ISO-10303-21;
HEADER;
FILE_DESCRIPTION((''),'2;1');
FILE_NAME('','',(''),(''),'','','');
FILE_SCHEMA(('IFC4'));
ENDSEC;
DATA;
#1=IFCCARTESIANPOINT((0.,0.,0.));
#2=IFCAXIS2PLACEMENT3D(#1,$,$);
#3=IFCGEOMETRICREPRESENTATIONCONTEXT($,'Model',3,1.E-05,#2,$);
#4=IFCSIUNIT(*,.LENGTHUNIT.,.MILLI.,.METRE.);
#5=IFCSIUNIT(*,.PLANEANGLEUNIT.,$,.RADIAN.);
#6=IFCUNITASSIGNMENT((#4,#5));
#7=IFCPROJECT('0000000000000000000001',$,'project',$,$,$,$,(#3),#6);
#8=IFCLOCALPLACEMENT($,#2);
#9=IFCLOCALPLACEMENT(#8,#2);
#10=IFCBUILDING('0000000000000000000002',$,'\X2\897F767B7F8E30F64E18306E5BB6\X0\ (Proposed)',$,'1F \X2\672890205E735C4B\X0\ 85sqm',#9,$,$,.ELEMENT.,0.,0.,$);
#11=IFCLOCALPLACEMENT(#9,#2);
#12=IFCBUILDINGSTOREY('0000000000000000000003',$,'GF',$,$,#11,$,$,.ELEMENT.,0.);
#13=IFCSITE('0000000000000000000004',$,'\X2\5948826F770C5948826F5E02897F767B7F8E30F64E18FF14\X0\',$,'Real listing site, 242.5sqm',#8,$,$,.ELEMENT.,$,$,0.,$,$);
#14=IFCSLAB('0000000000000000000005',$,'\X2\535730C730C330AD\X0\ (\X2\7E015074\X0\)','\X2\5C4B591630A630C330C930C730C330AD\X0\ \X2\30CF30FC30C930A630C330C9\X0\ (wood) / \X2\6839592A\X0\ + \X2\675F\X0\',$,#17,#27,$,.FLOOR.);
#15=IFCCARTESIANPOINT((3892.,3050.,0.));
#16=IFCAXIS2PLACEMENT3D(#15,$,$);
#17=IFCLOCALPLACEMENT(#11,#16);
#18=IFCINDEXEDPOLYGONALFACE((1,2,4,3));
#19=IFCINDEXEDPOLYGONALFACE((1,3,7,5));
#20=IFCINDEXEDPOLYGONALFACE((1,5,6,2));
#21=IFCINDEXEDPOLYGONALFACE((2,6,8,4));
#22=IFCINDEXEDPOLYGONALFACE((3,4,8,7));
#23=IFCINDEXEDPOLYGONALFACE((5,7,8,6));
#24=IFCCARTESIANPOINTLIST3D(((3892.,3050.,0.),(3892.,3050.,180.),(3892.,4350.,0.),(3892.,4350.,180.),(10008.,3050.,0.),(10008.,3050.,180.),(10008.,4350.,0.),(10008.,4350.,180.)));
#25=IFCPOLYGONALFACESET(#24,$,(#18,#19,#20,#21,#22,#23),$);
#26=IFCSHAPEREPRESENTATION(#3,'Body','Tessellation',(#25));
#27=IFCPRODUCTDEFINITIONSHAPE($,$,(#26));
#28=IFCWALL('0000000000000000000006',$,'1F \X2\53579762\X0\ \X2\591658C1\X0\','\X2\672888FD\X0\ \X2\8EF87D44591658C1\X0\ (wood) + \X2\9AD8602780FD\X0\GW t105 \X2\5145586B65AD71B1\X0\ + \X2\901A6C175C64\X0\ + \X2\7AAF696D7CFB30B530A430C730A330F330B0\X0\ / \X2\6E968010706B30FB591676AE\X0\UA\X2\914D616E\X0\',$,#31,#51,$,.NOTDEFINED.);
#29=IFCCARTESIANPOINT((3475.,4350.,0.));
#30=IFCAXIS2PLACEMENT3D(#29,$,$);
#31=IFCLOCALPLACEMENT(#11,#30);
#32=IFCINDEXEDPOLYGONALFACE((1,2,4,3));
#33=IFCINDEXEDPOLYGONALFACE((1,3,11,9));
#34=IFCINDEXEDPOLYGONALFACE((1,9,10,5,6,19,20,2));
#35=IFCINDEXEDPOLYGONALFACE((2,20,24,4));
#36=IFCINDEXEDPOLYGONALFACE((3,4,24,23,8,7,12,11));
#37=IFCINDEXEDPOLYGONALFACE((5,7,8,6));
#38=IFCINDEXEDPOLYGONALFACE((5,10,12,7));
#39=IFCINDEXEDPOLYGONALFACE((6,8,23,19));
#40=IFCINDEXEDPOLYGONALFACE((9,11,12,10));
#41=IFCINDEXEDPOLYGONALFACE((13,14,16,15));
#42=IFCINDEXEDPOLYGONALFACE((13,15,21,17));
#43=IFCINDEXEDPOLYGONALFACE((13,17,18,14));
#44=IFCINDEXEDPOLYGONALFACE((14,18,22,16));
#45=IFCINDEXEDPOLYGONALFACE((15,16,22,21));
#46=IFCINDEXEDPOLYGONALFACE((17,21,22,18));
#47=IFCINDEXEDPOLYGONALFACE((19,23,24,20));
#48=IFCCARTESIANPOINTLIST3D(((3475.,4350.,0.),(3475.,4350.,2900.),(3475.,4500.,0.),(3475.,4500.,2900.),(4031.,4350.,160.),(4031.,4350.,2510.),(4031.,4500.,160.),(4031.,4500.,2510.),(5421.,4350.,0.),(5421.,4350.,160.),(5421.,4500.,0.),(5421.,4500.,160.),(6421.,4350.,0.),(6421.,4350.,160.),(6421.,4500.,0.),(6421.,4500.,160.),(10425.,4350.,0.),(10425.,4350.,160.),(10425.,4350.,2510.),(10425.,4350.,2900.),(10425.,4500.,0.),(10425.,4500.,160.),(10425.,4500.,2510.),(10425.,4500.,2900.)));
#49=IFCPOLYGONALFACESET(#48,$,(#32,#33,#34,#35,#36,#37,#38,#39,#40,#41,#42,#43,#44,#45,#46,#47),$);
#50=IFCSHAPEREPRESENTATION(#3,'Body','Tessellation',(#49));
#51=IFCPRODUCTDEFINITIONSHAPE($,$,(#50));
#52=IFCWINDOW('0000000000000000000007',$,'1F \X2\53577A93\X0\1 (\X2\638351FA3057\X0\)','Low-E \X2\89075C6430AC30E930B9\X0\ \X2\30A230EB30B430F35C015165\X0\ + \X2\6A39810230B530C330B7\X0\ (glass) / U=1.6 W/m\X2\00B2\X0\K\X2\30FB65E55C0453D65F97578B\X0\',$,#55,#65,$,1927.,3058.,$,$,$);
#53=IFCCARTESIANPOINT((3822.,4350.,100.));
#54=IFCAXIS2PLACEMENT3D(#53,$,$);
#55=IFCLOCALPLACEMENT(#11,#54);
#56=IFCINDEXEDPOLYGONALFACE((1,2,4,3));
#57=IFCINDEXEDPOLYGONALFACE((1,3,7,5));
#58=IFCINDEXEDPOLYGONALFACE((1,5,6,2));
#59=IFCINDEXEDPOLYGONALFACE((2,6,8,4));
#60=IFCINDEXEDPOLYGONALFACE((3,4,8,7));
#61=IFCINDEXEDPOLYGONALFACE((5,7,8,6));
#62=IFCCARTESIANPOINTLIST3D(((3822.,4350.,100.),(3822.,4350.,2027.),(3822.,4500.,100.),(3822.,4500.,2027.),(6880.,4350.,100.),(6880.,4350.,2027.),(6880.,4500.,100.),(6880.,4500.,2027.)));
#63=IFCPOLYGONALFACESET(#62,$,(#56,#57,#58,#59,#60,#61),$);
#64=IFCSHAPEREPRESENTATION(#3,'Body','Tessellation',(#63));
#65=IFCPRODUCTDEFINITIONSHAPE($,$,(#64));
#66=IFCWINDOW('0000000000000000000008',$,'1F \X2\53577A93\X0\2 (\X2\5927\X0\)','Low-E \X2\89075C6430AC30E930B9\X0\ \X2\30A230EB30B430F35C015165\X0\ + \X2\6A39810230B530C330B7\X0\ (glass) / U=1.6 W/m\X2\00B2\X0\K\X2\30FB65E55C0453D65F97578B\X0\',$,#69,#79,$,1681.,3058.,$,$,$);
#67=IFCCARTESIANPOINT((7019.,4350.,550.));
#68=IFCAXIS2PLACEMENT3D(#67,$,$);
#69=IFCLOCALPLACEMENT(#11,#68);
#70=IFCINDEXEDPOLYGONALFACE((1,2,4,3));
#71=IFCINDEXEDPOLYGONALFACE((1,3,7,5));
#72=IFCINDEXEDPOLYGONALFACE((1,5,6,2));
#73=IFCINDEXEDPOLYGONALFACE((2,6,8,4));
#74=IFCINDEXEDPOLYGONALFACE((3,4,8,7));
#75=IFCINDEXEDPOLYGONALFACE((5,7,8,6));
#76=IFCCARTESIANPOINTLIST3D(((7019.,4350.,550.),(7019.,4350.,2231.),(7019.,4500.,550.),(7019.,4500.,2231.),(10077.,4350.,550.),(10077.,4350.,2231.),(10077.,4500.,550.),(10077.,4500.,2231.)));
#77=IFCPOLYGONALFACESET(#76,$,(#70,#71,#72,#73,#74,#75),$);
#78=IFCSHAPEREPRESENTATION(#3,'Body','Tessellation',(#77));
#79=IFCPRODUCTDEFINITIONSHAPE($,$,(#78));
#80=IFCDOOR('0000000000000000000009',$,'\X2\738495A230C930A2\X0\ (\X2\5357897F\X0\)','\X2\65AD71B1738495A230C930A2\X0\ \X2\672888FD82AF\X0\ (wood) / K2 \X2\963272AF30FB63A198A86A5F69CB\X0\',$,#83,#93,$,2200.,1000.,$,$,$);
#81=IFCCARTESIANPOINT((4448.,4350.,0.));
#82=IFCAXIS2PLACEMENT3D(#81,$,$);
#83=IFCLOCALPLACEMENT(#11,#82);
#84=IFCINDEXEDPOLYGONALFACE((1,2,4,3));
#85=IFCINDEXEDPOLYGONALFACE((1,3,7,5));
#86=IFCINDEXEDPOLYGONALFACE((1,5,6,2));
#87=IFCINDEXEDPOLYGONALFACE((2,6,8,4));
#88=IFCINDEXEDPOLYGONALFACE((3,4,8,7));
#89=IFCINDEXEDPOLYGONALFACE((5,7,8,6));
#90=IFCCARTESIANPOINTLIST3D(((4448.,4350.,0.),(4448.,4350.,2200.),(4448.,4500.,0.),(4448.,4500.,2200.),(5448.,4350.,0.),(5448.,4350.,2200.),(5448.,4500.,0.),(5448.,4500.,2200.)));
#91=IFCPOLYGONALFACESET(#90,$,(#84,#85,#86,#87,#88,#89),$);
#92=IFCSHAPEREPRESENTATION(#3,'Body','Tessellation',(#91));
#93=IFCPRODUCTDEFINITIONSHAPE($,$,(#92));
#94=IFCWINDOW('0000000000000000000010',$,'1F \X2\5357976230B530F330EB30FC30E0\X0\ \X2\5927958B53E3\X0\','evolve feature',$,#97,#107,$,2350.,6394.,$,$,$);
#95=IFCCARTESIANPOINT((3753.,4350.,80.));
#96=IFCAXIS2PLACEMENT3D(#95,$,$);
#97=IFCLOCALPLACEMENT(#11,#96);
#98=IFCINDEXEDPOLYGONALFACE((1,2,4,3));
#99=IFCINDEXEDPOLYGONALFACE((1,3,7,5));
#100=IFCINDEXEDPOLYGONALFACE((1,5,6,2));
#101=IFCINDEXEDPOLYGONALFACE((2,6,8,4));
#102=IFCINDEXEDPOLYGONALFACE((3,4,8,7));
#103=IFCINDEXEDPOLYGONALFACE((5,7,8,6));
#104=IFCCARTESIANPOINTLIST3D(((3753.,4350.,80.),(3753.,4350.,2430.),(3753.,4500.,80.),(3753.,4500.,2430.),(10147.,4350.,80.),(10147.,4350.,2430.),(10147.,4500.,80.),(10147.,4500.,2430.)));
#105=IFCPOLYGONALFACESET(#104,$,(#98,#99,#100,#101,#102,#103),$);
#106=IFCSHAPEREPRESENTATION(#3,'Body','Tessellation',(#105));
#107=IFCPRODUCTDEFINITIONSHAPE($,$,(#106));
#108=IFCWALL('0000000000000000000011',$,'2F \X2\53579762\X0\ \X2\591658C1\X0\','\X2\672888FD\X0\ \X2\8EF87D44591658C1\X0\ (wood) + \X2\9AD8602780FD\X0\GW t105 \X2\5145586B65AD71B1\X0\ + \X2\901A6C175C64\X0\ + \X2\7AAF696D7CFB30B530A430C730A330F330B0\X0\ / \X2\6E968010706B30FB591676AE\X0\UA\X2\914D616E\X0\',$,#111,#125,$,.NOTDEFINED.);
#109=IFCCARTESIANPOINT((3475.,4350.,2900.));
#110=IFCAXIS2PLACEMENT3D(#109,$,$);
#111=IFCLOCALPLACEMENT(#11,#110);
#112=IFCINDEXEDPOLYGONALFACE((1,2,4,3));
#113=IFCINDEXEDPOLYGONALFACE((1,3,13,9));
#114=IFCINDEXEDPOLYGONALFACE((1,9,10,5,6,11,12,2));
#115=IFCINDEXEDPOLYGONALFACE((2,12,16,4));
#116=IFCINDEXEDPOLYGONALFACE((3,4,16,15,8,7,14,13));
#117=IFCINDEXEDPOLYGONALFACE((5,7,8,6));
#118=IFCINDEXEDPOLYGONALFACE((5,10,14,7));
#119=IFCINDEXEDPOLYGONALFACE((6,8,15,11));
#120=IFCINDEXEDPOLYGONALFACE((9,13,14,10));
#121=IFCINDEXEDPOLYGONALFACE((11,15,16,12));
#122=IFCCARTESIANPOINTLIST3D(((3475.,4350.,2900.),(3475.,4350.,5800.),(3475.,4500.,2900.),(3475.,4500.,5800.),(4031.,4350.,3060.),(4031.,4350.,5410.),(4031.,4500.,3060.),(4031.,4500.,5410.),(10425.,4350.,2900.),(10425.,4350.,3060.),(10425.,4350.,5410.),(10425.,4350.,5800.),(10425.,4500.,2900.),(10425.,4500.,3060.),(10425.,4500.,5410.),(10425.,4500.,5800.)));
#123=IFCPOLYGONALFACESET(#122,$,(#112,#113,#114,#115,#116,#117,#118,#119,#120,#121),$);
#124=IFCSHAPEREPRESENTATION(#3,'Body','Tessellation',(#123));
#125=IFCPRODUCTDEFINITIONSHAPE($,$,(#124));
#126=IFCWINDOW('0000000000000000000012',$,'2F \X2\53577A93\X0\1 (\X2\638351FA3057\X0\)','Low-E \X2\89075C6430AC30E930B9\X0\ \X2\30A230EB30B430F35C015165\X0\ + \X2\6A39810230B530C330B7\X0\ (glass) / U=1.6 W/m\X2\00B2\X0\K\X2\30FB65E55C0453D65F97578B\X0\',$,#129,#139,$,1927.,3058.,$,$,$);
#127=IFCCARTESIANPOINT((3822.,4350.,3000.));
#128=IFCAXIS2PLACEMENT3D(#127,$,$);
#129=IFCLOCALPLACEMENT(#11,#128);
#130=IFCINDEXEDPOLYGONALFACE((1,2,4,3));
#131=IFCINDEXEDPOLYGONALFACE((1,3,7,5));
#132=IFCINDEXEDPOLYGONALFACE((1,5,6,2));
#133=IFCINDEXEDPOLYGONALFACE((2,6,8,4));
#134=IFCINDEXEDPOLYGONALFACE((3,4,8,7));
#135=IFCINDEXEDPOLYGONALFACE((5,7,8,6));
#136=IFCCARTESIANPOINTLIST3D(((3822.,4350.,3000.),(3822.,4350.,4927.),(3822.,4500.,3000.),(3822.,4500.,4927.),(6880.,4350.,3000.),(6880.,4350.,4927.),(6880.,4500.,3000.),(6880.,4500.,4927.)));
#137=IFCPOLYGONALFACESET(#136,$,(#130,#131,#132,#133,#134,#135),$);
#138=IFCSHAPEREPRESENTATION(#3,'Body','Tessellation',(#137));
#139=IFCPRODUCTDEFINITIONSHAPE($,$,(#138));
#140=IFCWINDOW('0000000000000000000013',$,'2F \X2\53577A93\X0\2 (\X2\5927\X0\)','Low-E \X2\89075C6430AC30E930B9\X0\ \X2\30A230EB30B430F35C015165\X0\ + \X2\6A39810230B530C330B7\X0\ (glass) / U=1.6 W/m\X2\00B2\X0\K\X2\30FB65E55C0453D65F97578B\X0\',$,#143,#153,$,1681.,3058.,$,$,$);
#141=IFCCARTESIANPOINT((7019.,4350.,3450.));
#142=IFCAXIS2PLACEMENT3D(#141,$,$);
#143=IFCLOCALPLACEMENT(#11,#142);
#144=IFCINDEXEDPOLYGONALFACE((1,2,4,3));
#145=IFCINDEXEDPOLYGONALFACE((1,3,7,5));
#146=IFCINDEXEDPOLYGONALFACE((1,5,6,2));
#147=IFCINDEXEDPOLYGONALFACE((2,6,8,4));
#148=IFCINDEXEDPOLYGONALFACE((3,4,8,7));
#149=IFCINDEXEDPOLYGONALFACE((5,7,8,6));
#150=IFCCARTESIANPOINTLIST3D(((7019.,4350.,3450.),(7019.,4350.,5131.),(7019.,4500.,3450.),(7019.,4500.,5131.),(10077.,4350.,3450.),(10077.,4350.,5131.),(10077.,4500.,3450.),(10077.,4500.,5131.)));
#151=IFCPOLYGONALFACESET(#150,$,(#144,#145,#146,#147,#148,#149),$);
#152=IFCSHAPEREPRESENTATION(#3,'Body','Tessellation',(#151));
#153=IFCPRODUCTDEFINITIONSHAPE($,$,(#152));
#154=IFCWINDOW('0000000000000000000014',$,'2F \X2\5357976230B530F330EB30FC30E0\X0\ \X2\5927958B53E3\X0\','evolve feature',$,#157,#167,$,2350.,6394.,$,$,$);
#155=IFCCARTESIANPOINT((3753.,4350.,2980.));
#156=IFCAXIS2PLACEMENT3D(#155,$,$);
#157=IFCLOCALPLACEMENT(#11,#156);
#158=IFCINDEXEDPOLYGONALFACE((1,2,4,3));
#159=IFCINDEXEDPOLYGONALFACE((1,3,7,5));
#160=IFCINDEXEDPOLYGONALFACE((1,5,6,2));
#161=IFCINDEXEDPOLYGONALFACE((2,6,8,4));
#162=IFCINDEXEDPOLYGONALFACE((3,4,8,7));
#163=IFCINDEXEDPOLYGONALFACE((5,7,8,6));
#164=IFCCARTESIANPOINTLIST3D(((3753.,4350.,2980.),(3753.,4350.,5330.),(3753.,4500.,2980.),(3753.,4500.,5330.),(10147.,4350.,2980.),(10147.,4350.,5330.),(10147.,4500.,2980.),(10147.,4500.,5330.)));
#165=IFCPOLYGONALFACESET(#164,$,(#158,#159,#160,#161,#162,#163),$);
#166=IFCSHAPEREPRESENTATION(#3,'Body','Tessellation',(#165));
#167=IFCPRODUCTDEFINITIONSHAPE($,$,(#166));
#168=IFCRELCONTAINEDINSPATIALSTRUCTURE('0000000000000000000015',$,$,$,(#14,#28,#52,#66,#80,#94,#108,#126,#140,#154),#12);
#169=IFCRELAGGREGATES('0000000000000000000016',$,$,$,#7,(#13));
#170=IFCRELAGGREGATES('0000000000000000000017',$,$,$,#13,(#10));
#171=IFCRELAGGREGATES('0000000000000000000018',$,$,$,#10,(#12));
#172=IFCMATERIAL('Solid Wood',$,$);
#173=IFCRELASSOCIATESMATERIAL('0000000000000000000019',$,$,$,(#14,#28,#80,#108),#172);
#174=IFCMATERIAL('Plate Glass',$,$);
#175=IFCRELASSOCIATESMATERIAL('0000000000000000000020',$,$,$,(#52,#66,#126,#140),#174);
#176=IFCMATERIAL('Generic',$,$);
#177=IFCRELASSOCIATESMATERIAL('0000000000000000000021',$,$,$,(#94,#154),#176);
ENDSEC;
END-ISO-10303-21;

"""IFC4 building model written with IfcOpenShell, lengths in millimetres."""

from ifc_helpers import new_model, si_unit, frame, frame_2d, origin, place, context, project, spatial, rectangle, extrude, material, element, fill, save


model = new_model("IFC4")

# Units and contexts
model_context = context("Model", 3, precision=1e-05, world=origin())
ifc_project = project(units=[si_unit("LENGTHUNIT", "METRE", prefix="MILLI"), si_unit("PLANEANGLEUNIT", "RADIAN")], contexts=[model_context])

# Site, building, storey
site_placement = place(None, origin())
site = spatial("IfcSite", under=ifc_project, at=site_placement, Name="奈良県奈良市西登美ヶ丘４", ObjectType="Real listing site, 242.5sqm", CompositionType="ELEMENT", RefElevation=0.0)
building_placement = place(site_placement, origin())
building = spatial("IfcBuilding", under=site, at=building_placement, Name="西登美ヶ丘の家 (Proposed)", ObjectType="1F 木造平屋 85sqm", CompositionType="ELEMENT", ElevationOfRefHeight=0.0, ElevationOfTerrain=0.0)
storey_placement = place(building_placement, origin())
storey = spatial("IfcBuildingStorey", under=building, at=storey_placement, Name="GF", CompositionType="ELEMENT", Elevation=0.0)

# Slab
ifc_material_1 = material(Name="Solid Wood")
slab_1_placement = place(storey_placement, frame((3892.0, 3050.0, 0.0)))
element("IfcSlab", 1, at=slab_1_placement, inside=storey, material=ifc_material_1, Name="南デッキ (縁側)", Description="屋外ウッドデッキ ハードウッド (wood) / 根太 + 束", PredefinedType="FLOOR", context=model_context, shape_type="SweptSolid", body=[
    extrude(rectangle(XDim=6116.0, YDim=1300.0, at=frame_2d((3058.0, 650.0))), frame((3892.0, 3050.0, 0.0)), (0.0, 0.0, 1.0), 180.0),
])
ifc_material_2 = material(Name="Generic")

# Wall, openings, windows, door
wall_1_placement = place(storey_placement, frame((3475.0, 4350.0, 0.0)))
wall_1 = element("IfcWall", 2, at=wall_1_placement, inside=storey, material=ifc_material_1, Name="1F 南面 外壁", Description="木製 軸組外壁 (wood) + 高性能GW t105 充填断熱 + 通気層 + 窯業系サイディング / 準耐火・外皮UA配慮", PredefinedType="NOTDEFINED", context=model_context, shape_type="SweptSolid", body=[
    extrude(rectangle(XDim=6950.0, YDim=150.0, at=frame_2d((3475.0, 75.0))), frame((3475.0, 4350.0, 0.0)), (0.0, 0.0, 1.0), 2900.0),
])
opening_1_placement = place(storey_placement, frame((3822.0, 4350.0, 100.0)))
opening_1 = element("IfcOpeningElement", 3, at=opening_1_placement, cuts=wall_1, PredefinedType="NOTDEFINED", context=model_context, shape_type="SweptSolid", body=[
    extrude(rectangle(XDim=3058.0, YDim=150.0, at=frame_2d((1529.0, 75.0))), frame((3822.0, 4350.0, 100.0)), (0.0, 0.0, 1.0), 1927.0),
])
opening_2_placement = place(storey_placement, frame((7019.0, 4350.0, 550.0)))
opening_2 = element("IfcOpeningElement", 4, at=opening_2_placement, cuts=wall_1, PredefinedType="NOTDEFINED", context=model_context, shape_type="SweptSolid", body=[
    extrude(rectangle(XDim=3058.0, YDim=150.0, at=frame_2d((1529.0, 75.0))), frame((7019.0, 4350.0, 550.0)), (0.0, 0.0, 1.0), 1681.0),
])
opening_3_placement = place(storey_placement, frame((4448.0, 4350.0, 0.0)))
opening_3 = element("IfcOpeningElement", 5, at=opening_3_placement, cuts=wall_1, PredefinedType="NOTDEFINED", context=model_context, shape_type="SweptSolid", body=[
    extrude(rectangle(XDim=1000.0, YDim=150.0, at=frame_2d((500.0, 75.0))), frame((4448.0, 4350.0, 0.0)), (0.0, 0.0, 1.0), 2200.0),
])
opening_4_placement = place(storey_placement, frame((3753.0, 4350.0, 80.0)))
opening_4 = element("IfcOpeningElement", 6, at=opening_4_placement, cuts=wall_1, PredefinedType="NOTDEFINED", context=model_context, shape_type="SweptSolid", body=[
    extrude(rectangle(XDim=6394.0, YDim=150.0, at=frame_2d((3197.0, 75.0))), frame((3753.0, 4350.0, 80.0)), (0.0, 0.0, 1.0), 2350.0),
])
ifc_material_3 = material(Name="Plate Glass")
window_1_placement = place(storey_placement, frame((3822.0, 4350.0, 100.0)))
window_1 = element("IfcWindow", 7, at=window_1_placement, inside=storey, material=ifc_material_3, Name="1F 南窓1 (掃出し)", Description="Low-E 複層ガラス アルゴン封入 + 樹脂サッシ (glass) / U=1.6 W/m²K・日射取得型", OverallHeight=1927.0, OverallWidth=3058.0, context=model_context, shape_type="SweptSolid", body=[
    extrude(rectangle(XDim=3058.0, YDim=150.0, at=frame_2d((1529.0, 75.0))), frame((3822.0, 4350.0, 100.0)), (0.0, 0.0, 1.0), 1927.0),
])
fill(opening_1, window_1)
window_2_placement = place(storey_placement, frame((7019.0, 4350.0, 550.0)))
window_2 = element("IfcWindow", 8, at=window_2_placement, inside=storey, material=ifc_material_3, Name="1F 南窓2 (大)", Description="Low-E 複層ガラス アルゴン封入 + 樹脂サッシ (glass) / U=1.6 W/m²K・日射取得型", OverallHeight=1681.0, OverallWidth=3058.0, context=model_context, shape_type="SweptSolid", body=[
    extrude(rectangle(XDim=3058.0, YDim=150.0, at=frame_2d((1529.0, 75.0))), frame((7019.0, 4350.0, 550.0)), (0.0, 0.0, 1.0), 1681.0),
])
fill(opening_2, window_2)
door_placement = place(storey_placement, frame((4448.0, 4350.0, 0.0)))
door = element("IfcDoor", 9, at=door_placement, inside=storey, material=ifc_material_1, Name="玄関ドア (南西)", Description="断熱玄関ドア 木製芯 (wood) / K2 防犯・採風機構", OverallHeight=2200.0, OverallWidth=1000.0, context=model_context, shape_type="SweptSolid", body=[
    extrude(rectangle(XDim=1000.0, YDim=150.0, at=frame_2d((500.0, 75.0))), frame((4448.0, 4350.0, 0.0)), (0.0, 0.0, 1.0), 2200.0),
])
fill(opening_3, door)
window_3_placement = place(storey_placement, frame((3753.0, 4350.0, 80.0)))
window_3 = element("IfcWindow", 10, at=window_3_placement, inside=storey, material=ifc_material_2, Name="1F 南面サンルーム 大開口", Description="evolve feature", OverallHeight=2350.0, OverallWidth=6394.0, context=model_context, shape_type="SweptSolid", body=[
    extrude(rectangle(XDim=6394.0, YDim=150.0, at=frame_2d((3197.0, 75.0))), frame((3753.0, 4350.0, 80.0)), (0.0, 0.0, 1.0), 2350.0),
])
fill(opening_4, window_3)

# Wall, openings, windows
wall_2_placement = place(storey_placement, frame((3475.0, 4350.0, 2900.0)))
wall_2 = element("IfcWall", 11, at=wall_2_placement, inside=storey, material=ifc_material_1, Name="2F 南面 外壁", Description="木製 軸組外壁 (wood) + 高性能GW t105 充填断熱 + 通気層 + 窯業系サイディング / 準耐火・外皮UA配慮", PredefinedType="NOTDEFINED", context=model_context, shape_type="SweptSolid", body=[
    extrude(rectangle(XDim=6950.0, YDim=150.0, at=frame_2d((3475.0, 75.0))), frame((3475.0, 4350.0, 2900.0)), (0.0, 0.0, 1.0), 2900.0),
])
opening_5_placement = place(storey_placement, frame((3822.0, 4350.0, 3000.0)))
opening_5 = element("IfcOpeningElement", 12, at=opening_5_placement, cuts=wall_2, PredefinedType="NOTDEFINED", context=model_context, shape_type="SweptSolid", body=[
    extrude(rectangle(XDim=3058.0, YDim=150.0, at=frame_2d((1529.0, 75.0))), frame((3822.0, 4350.0, 3000.0)), (0.0, 0.0, 1.0), 1927.0),
])
opening_6_placement = place(storey_placement, frame((7019.0, 4350.0, 3450.0)))
opening_6 = element("IfcOpeningElement", 13, at=opening_6_placement, cuts=wall_2, PredefinedType="NOTDEFINED", context=model_context, shape_type="SweptSolid", body=[
    extrude(rectangle(XDim=3058.0, YDim=150.0, at=frame_2d((1529.0, 75.0))), frame((7019.0, 4350.0, 3450.0)), (0.0, 0.0, 1.0), 1681.0),
])
opening_7_placement = place(storey_placement, frame((3753.0, 4350.0, 2980.0)))
opening_7 = element("IfcOpeningElement", 14, at=opening_7_placement, cuts=wall_2, PredefinedType="NOTDEFINED", context=model_context, shape_type="SweptSolid", body=[
    extrude(rectangle(XDim=6394.0, YDim=150.0, at=frame_2d((3197.0, 75.0))), frame((3753.0, 4350.0, 2980.0)), (0.0, 0.0, 1.0), 2350.0),
])
window_4_placement = place(storey_placement, frame((3822.0, 4350.0, 3000.0)))
window_4 = element("IfcWindow", 15, at=window_4_placement, inside=storey, material=ifc_material_3, Name="2F 南窓1 (掃出し)", Description="Low-E 複層ガラス アルゴン封入 + 樹脂サッシ (glass) / U=1.6 W/m²K・日射取得型", OverallHeight=1927.0, OverallWidth=3058.0, context=model_context, shape_type="SweptSolid", body=[
    extrude(rectangle(XDim=3058.0, YDim=150.0, at=frame_2d((1529.0, 75.0))), frame((3822.0, 4350.0, 3000.0)), (0.0, 0.0, 1.0), 1927.0),
])
fill(opening_5, window_4)
window_5_placement = place(storey_placement, frame((7019.0, 4350.0, 3450.0)))
window_5 = element("IfcWindow", 16, at=window_5_placement, inside=storey, material=ifc_material_3, Name="2F 南窓2 (大)", Description="Low-E 複層ガラス アルゴン封入 + 樹脂サッシ (glass) / U=1.6 W/m²K・日射取得型", OverallHeight=1681.0, OverallWidth=3058.0, context=model_context, shape_type="SweptSolid", body=[
    extrude(rectangle(XDim=3058.0, YDim=150.0, at=frame_2d((1529.0, 75.0))), frame((7019.0, 4350.0, 3450.0)), (0.0, 0.0, 1.0), 1681.0),
])
fill(opening_6, window_5)
window_6_placement = place(storey_placement, frame((3753.0, 4350.0, 2980.0)))
window_6 = element("IfcWindow", 17, at=window_6_placement, inside=storey, material=ifc_material_2, Name="2F 南面サンルーム 大開口", Description="evolve feature", OverallHeight=2350.0, OverallWidth=6394.0, context=model_context, shape_type="SweptSolid", body=[
    extrude(rectangle(XDim=6394.0, YDim=150.0, at=frame_2d((3197.0, 75.0))), frame((3753.0, 4350.0, 2980.0)), (0.0, 0.0, 1.0), 2350.0),
])
fill(opening_7, window_6)

save(model, "model.ifc")
